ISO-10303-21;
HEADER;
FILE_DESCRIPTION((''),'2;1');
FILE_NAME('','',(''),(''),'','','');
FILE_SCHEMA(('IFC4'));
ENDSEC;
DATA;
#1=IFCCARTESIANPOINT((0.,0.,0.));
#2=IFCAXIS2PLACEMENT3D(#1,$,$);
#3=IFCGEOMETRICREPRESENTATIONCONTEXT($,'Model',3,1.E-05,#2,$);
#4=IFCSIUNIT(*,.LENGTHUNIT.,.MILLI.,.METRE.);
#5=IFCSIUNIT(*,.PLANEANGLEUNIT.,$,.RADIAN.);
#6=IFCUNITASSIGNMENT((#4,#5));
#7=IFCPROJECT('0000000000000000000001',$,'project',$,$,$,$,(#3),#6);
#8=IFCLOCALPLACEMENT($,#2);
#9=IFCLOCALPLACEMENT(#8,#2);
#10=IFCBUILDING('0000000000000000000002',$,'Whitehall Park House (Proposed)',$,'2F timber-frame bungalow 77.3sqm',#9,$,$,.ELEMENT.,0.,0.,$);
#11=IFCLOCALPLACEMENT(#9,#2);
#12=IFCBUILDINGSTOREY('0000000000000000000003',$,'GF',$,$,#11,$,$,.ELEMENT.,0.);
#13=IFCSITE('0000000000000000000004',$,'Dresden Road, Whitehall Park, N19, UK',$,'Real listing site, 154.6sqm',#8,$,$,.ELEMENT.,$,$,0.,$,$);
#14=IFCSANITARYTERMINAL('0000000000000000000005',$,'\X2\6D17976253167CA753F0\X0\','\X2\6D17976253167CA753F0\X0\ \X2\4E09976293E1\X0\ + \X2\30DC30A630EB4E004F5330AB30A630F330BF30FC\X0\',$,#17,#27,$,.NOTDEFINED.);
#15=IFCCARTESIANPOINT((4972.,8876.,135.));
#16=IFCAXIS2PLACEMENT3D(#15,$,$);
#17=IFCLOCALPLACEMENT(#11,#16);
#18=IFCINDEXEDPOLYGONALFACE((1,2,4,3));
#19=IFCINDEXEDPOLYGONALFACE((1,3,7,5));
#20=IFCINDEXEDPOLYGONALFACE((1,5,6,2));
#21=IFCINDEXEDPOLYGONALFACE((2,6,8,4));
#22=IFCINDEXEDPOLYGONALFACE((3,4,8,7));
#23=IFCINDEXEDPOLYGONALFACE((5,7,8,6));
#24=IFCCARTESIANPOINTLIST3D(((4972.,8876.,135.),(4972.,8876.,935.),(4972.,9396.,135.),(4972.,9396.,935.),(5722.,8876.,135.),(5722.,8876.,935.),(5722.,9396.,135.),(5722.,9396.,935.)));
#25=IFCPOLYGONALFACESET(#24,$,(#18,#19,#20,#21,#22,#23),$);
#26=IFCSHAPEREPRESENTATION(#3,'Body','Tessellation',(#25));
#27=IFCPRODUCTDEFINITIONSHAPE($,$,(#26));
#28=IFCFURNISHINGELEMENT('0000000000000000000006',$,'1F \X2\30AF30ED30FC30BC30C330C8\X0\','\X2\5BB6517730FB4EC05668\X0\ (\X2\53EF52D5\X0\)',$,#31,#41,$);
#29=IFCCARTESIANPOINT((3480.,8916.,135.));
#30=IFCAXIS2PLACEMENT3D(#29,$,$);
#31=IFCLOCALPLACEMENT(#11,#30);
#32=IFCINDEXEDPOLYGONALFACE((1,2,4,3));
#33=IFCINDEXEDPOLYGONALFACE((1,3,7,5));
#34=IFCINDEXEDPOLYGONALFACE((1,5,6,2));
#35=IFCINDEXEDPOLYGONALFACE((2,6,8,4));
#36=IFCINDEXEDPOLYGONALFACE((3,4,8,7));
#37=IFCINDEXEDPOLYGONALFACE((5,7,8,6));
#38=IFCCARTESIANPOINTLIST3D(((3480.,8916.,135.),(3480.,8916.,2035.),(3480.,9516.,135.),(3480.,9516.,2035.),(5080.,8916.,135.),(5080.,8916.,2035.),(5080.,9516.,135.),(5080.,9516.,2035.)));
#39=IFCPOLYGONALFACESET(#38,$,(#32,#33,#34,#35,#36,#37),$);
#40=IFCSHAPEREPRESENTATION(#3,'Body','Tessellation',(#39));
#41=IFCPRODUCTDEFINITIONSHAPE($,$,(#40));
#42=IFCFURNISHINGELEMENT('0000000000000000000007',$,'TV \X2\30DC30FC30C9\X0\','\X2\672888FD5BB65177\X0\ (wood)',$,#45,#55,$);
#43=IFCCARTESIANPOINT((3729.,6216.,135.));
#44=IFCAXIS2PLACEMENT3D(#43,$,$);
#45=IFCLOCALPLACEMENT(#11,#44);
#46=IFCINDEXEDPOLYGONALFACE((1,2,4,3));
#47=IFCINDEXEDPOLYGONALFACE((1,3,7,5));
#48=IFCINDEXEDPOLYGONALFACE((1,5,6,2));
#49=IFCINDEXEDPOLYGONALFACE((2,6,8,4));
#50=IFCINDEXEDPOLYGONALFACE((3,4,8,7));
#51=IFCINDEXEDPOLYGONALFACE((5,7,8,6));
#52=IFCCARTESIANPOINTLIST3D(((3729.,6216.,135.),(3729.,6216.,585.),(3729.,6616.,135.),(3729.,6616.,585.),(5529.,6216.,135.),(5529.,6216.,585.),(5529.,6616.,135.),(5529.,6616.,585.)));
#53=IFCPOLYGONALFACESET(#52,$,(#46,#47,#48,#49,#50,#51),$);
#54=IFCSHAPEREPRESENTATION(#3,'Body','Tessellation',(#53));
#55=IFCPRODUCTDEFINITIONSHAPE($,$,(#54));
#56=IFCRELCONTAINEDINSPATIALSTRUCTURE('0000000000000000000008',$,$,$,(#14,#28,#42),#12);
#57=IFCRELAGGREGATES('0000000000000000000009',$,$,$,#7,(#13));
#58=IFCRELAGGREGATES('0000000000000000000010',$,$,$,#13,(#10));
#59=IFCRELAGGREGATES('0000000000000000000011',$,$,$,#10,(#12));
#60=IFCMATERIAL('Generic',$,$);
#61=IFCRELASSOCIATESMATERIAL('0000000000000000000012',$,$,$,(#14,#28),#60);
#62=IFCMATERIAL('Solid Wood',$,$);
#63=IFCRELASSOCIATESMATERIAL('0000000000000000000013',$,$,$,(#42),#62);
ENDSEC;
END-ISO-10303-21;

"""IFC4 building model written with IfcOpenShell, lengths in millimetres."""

from ifc_helpers import new_model, si_unit, frame, frame_2d, origin, place, context, project, spatial, rectangle, extrude, material, element, save


model = new_model("IFC4")

# Units and contexts
model_context = context("Model", 3, precision=1e-05, world=origin())
ifc_project = project(units=[si_unit("LENGTHUNIT", "METRE", prefix="MILLI"), si_unit("PLANEANGLEUNIT", "RADIAN")], contexts=[model_context])

# Site, building, storey
site_placement = place(None, origin())
site = spatial("IfcSite", under=ifc_project, at=site_placement, Name="Dresden Road, Whitehall Park, N19, UK", ObjectType="Real listing site, 154.6sqm", CompositionType="ELEMENT", RefElevation=0.0)
building_placement = place(site_placement, origin())
building = spatial("IfcBuilding", under=site, at=building_placement, Name="Whitehall Park House (Proposed)", ObjectType="2F timber-frame bungalow 77.3sqm", CompositionType="ELEMENT", ElevationOfRefHeight=0.0, ElevationOfTerrain=0.0)
storey_placement = place(building_placement, origin())
storey = spatial("IfcBuildingStorey", under=building, at=storey_placement, Name="GF", CompositionType="ELEMENT", Elevation=0.0)

# Shared definitions
ifc_material_1 = material(Name="Solid Wood")

# Shared definitions
ifc_material_2 = material(Name="Generic")

# Sanitary terminal
sanitary_terminal_1_placement = place(storey_placement, frame((4972.0, 8876.0, 135.0)))
element("IfcSanitaryTerminal", 1, at=sanitary_terminal_1_placement, inside=storey, material=ifc_material_2, Name="洗面化粧台", Description="洗面化粧台 三面鏡 + ボウル一体カウンター", PredefinedType="NOTDEFINED", context=model_context, shape_type="SweptSolid", body=[
    extrude(rectangle(XDim=750.0, YDim=520.0, at=frame_2d((375.0, 260.0))), frame((4972.0, 8876.0, 135.0)), (0.0, 0.0, 1.0), 800.0),
])

# Furnishing elements
furnishing_1_placement = place(storey_placement, frame((3480.0, 8916.0, 135.0)))
element("IfcFurnishingElement", 2, at=furnishing_1_placement, inside=storey, material=ifc_material_2, Name="1F クローゼット", Description="家具・什器 (可動)", context=model_context, shape_type="SweptSolid", body=[
    extrude(rectangle(XDim=1600.0, YDim=600.0, at=frame_2d((800.0, 300.0))), frame((3480.0, 8916.0, 135.0)), (0.0, 0.0, 1.0), 1900.0),
])
furnishing_2_placement = place(storey_placement, frame((3729.0, 6216.0, 135.0)))
element("IfcFurnishingElement", 3, at=furnishing_2_placement, inside=storey, material=ifc_material_1, Name="TV ボード", Description="木製家具 (wood)", context=model_context, shape_type="SweptSolid", body=[
    extrude(rectangle(XDim=1800.0, YDim=400.0, at=frame_2d((900.0, 200.0))), frame((3729.0, 6216.0, 135.0)), (0.0, 0.0, 1.0), 450.0),
])

save(model, "model.ifc")
